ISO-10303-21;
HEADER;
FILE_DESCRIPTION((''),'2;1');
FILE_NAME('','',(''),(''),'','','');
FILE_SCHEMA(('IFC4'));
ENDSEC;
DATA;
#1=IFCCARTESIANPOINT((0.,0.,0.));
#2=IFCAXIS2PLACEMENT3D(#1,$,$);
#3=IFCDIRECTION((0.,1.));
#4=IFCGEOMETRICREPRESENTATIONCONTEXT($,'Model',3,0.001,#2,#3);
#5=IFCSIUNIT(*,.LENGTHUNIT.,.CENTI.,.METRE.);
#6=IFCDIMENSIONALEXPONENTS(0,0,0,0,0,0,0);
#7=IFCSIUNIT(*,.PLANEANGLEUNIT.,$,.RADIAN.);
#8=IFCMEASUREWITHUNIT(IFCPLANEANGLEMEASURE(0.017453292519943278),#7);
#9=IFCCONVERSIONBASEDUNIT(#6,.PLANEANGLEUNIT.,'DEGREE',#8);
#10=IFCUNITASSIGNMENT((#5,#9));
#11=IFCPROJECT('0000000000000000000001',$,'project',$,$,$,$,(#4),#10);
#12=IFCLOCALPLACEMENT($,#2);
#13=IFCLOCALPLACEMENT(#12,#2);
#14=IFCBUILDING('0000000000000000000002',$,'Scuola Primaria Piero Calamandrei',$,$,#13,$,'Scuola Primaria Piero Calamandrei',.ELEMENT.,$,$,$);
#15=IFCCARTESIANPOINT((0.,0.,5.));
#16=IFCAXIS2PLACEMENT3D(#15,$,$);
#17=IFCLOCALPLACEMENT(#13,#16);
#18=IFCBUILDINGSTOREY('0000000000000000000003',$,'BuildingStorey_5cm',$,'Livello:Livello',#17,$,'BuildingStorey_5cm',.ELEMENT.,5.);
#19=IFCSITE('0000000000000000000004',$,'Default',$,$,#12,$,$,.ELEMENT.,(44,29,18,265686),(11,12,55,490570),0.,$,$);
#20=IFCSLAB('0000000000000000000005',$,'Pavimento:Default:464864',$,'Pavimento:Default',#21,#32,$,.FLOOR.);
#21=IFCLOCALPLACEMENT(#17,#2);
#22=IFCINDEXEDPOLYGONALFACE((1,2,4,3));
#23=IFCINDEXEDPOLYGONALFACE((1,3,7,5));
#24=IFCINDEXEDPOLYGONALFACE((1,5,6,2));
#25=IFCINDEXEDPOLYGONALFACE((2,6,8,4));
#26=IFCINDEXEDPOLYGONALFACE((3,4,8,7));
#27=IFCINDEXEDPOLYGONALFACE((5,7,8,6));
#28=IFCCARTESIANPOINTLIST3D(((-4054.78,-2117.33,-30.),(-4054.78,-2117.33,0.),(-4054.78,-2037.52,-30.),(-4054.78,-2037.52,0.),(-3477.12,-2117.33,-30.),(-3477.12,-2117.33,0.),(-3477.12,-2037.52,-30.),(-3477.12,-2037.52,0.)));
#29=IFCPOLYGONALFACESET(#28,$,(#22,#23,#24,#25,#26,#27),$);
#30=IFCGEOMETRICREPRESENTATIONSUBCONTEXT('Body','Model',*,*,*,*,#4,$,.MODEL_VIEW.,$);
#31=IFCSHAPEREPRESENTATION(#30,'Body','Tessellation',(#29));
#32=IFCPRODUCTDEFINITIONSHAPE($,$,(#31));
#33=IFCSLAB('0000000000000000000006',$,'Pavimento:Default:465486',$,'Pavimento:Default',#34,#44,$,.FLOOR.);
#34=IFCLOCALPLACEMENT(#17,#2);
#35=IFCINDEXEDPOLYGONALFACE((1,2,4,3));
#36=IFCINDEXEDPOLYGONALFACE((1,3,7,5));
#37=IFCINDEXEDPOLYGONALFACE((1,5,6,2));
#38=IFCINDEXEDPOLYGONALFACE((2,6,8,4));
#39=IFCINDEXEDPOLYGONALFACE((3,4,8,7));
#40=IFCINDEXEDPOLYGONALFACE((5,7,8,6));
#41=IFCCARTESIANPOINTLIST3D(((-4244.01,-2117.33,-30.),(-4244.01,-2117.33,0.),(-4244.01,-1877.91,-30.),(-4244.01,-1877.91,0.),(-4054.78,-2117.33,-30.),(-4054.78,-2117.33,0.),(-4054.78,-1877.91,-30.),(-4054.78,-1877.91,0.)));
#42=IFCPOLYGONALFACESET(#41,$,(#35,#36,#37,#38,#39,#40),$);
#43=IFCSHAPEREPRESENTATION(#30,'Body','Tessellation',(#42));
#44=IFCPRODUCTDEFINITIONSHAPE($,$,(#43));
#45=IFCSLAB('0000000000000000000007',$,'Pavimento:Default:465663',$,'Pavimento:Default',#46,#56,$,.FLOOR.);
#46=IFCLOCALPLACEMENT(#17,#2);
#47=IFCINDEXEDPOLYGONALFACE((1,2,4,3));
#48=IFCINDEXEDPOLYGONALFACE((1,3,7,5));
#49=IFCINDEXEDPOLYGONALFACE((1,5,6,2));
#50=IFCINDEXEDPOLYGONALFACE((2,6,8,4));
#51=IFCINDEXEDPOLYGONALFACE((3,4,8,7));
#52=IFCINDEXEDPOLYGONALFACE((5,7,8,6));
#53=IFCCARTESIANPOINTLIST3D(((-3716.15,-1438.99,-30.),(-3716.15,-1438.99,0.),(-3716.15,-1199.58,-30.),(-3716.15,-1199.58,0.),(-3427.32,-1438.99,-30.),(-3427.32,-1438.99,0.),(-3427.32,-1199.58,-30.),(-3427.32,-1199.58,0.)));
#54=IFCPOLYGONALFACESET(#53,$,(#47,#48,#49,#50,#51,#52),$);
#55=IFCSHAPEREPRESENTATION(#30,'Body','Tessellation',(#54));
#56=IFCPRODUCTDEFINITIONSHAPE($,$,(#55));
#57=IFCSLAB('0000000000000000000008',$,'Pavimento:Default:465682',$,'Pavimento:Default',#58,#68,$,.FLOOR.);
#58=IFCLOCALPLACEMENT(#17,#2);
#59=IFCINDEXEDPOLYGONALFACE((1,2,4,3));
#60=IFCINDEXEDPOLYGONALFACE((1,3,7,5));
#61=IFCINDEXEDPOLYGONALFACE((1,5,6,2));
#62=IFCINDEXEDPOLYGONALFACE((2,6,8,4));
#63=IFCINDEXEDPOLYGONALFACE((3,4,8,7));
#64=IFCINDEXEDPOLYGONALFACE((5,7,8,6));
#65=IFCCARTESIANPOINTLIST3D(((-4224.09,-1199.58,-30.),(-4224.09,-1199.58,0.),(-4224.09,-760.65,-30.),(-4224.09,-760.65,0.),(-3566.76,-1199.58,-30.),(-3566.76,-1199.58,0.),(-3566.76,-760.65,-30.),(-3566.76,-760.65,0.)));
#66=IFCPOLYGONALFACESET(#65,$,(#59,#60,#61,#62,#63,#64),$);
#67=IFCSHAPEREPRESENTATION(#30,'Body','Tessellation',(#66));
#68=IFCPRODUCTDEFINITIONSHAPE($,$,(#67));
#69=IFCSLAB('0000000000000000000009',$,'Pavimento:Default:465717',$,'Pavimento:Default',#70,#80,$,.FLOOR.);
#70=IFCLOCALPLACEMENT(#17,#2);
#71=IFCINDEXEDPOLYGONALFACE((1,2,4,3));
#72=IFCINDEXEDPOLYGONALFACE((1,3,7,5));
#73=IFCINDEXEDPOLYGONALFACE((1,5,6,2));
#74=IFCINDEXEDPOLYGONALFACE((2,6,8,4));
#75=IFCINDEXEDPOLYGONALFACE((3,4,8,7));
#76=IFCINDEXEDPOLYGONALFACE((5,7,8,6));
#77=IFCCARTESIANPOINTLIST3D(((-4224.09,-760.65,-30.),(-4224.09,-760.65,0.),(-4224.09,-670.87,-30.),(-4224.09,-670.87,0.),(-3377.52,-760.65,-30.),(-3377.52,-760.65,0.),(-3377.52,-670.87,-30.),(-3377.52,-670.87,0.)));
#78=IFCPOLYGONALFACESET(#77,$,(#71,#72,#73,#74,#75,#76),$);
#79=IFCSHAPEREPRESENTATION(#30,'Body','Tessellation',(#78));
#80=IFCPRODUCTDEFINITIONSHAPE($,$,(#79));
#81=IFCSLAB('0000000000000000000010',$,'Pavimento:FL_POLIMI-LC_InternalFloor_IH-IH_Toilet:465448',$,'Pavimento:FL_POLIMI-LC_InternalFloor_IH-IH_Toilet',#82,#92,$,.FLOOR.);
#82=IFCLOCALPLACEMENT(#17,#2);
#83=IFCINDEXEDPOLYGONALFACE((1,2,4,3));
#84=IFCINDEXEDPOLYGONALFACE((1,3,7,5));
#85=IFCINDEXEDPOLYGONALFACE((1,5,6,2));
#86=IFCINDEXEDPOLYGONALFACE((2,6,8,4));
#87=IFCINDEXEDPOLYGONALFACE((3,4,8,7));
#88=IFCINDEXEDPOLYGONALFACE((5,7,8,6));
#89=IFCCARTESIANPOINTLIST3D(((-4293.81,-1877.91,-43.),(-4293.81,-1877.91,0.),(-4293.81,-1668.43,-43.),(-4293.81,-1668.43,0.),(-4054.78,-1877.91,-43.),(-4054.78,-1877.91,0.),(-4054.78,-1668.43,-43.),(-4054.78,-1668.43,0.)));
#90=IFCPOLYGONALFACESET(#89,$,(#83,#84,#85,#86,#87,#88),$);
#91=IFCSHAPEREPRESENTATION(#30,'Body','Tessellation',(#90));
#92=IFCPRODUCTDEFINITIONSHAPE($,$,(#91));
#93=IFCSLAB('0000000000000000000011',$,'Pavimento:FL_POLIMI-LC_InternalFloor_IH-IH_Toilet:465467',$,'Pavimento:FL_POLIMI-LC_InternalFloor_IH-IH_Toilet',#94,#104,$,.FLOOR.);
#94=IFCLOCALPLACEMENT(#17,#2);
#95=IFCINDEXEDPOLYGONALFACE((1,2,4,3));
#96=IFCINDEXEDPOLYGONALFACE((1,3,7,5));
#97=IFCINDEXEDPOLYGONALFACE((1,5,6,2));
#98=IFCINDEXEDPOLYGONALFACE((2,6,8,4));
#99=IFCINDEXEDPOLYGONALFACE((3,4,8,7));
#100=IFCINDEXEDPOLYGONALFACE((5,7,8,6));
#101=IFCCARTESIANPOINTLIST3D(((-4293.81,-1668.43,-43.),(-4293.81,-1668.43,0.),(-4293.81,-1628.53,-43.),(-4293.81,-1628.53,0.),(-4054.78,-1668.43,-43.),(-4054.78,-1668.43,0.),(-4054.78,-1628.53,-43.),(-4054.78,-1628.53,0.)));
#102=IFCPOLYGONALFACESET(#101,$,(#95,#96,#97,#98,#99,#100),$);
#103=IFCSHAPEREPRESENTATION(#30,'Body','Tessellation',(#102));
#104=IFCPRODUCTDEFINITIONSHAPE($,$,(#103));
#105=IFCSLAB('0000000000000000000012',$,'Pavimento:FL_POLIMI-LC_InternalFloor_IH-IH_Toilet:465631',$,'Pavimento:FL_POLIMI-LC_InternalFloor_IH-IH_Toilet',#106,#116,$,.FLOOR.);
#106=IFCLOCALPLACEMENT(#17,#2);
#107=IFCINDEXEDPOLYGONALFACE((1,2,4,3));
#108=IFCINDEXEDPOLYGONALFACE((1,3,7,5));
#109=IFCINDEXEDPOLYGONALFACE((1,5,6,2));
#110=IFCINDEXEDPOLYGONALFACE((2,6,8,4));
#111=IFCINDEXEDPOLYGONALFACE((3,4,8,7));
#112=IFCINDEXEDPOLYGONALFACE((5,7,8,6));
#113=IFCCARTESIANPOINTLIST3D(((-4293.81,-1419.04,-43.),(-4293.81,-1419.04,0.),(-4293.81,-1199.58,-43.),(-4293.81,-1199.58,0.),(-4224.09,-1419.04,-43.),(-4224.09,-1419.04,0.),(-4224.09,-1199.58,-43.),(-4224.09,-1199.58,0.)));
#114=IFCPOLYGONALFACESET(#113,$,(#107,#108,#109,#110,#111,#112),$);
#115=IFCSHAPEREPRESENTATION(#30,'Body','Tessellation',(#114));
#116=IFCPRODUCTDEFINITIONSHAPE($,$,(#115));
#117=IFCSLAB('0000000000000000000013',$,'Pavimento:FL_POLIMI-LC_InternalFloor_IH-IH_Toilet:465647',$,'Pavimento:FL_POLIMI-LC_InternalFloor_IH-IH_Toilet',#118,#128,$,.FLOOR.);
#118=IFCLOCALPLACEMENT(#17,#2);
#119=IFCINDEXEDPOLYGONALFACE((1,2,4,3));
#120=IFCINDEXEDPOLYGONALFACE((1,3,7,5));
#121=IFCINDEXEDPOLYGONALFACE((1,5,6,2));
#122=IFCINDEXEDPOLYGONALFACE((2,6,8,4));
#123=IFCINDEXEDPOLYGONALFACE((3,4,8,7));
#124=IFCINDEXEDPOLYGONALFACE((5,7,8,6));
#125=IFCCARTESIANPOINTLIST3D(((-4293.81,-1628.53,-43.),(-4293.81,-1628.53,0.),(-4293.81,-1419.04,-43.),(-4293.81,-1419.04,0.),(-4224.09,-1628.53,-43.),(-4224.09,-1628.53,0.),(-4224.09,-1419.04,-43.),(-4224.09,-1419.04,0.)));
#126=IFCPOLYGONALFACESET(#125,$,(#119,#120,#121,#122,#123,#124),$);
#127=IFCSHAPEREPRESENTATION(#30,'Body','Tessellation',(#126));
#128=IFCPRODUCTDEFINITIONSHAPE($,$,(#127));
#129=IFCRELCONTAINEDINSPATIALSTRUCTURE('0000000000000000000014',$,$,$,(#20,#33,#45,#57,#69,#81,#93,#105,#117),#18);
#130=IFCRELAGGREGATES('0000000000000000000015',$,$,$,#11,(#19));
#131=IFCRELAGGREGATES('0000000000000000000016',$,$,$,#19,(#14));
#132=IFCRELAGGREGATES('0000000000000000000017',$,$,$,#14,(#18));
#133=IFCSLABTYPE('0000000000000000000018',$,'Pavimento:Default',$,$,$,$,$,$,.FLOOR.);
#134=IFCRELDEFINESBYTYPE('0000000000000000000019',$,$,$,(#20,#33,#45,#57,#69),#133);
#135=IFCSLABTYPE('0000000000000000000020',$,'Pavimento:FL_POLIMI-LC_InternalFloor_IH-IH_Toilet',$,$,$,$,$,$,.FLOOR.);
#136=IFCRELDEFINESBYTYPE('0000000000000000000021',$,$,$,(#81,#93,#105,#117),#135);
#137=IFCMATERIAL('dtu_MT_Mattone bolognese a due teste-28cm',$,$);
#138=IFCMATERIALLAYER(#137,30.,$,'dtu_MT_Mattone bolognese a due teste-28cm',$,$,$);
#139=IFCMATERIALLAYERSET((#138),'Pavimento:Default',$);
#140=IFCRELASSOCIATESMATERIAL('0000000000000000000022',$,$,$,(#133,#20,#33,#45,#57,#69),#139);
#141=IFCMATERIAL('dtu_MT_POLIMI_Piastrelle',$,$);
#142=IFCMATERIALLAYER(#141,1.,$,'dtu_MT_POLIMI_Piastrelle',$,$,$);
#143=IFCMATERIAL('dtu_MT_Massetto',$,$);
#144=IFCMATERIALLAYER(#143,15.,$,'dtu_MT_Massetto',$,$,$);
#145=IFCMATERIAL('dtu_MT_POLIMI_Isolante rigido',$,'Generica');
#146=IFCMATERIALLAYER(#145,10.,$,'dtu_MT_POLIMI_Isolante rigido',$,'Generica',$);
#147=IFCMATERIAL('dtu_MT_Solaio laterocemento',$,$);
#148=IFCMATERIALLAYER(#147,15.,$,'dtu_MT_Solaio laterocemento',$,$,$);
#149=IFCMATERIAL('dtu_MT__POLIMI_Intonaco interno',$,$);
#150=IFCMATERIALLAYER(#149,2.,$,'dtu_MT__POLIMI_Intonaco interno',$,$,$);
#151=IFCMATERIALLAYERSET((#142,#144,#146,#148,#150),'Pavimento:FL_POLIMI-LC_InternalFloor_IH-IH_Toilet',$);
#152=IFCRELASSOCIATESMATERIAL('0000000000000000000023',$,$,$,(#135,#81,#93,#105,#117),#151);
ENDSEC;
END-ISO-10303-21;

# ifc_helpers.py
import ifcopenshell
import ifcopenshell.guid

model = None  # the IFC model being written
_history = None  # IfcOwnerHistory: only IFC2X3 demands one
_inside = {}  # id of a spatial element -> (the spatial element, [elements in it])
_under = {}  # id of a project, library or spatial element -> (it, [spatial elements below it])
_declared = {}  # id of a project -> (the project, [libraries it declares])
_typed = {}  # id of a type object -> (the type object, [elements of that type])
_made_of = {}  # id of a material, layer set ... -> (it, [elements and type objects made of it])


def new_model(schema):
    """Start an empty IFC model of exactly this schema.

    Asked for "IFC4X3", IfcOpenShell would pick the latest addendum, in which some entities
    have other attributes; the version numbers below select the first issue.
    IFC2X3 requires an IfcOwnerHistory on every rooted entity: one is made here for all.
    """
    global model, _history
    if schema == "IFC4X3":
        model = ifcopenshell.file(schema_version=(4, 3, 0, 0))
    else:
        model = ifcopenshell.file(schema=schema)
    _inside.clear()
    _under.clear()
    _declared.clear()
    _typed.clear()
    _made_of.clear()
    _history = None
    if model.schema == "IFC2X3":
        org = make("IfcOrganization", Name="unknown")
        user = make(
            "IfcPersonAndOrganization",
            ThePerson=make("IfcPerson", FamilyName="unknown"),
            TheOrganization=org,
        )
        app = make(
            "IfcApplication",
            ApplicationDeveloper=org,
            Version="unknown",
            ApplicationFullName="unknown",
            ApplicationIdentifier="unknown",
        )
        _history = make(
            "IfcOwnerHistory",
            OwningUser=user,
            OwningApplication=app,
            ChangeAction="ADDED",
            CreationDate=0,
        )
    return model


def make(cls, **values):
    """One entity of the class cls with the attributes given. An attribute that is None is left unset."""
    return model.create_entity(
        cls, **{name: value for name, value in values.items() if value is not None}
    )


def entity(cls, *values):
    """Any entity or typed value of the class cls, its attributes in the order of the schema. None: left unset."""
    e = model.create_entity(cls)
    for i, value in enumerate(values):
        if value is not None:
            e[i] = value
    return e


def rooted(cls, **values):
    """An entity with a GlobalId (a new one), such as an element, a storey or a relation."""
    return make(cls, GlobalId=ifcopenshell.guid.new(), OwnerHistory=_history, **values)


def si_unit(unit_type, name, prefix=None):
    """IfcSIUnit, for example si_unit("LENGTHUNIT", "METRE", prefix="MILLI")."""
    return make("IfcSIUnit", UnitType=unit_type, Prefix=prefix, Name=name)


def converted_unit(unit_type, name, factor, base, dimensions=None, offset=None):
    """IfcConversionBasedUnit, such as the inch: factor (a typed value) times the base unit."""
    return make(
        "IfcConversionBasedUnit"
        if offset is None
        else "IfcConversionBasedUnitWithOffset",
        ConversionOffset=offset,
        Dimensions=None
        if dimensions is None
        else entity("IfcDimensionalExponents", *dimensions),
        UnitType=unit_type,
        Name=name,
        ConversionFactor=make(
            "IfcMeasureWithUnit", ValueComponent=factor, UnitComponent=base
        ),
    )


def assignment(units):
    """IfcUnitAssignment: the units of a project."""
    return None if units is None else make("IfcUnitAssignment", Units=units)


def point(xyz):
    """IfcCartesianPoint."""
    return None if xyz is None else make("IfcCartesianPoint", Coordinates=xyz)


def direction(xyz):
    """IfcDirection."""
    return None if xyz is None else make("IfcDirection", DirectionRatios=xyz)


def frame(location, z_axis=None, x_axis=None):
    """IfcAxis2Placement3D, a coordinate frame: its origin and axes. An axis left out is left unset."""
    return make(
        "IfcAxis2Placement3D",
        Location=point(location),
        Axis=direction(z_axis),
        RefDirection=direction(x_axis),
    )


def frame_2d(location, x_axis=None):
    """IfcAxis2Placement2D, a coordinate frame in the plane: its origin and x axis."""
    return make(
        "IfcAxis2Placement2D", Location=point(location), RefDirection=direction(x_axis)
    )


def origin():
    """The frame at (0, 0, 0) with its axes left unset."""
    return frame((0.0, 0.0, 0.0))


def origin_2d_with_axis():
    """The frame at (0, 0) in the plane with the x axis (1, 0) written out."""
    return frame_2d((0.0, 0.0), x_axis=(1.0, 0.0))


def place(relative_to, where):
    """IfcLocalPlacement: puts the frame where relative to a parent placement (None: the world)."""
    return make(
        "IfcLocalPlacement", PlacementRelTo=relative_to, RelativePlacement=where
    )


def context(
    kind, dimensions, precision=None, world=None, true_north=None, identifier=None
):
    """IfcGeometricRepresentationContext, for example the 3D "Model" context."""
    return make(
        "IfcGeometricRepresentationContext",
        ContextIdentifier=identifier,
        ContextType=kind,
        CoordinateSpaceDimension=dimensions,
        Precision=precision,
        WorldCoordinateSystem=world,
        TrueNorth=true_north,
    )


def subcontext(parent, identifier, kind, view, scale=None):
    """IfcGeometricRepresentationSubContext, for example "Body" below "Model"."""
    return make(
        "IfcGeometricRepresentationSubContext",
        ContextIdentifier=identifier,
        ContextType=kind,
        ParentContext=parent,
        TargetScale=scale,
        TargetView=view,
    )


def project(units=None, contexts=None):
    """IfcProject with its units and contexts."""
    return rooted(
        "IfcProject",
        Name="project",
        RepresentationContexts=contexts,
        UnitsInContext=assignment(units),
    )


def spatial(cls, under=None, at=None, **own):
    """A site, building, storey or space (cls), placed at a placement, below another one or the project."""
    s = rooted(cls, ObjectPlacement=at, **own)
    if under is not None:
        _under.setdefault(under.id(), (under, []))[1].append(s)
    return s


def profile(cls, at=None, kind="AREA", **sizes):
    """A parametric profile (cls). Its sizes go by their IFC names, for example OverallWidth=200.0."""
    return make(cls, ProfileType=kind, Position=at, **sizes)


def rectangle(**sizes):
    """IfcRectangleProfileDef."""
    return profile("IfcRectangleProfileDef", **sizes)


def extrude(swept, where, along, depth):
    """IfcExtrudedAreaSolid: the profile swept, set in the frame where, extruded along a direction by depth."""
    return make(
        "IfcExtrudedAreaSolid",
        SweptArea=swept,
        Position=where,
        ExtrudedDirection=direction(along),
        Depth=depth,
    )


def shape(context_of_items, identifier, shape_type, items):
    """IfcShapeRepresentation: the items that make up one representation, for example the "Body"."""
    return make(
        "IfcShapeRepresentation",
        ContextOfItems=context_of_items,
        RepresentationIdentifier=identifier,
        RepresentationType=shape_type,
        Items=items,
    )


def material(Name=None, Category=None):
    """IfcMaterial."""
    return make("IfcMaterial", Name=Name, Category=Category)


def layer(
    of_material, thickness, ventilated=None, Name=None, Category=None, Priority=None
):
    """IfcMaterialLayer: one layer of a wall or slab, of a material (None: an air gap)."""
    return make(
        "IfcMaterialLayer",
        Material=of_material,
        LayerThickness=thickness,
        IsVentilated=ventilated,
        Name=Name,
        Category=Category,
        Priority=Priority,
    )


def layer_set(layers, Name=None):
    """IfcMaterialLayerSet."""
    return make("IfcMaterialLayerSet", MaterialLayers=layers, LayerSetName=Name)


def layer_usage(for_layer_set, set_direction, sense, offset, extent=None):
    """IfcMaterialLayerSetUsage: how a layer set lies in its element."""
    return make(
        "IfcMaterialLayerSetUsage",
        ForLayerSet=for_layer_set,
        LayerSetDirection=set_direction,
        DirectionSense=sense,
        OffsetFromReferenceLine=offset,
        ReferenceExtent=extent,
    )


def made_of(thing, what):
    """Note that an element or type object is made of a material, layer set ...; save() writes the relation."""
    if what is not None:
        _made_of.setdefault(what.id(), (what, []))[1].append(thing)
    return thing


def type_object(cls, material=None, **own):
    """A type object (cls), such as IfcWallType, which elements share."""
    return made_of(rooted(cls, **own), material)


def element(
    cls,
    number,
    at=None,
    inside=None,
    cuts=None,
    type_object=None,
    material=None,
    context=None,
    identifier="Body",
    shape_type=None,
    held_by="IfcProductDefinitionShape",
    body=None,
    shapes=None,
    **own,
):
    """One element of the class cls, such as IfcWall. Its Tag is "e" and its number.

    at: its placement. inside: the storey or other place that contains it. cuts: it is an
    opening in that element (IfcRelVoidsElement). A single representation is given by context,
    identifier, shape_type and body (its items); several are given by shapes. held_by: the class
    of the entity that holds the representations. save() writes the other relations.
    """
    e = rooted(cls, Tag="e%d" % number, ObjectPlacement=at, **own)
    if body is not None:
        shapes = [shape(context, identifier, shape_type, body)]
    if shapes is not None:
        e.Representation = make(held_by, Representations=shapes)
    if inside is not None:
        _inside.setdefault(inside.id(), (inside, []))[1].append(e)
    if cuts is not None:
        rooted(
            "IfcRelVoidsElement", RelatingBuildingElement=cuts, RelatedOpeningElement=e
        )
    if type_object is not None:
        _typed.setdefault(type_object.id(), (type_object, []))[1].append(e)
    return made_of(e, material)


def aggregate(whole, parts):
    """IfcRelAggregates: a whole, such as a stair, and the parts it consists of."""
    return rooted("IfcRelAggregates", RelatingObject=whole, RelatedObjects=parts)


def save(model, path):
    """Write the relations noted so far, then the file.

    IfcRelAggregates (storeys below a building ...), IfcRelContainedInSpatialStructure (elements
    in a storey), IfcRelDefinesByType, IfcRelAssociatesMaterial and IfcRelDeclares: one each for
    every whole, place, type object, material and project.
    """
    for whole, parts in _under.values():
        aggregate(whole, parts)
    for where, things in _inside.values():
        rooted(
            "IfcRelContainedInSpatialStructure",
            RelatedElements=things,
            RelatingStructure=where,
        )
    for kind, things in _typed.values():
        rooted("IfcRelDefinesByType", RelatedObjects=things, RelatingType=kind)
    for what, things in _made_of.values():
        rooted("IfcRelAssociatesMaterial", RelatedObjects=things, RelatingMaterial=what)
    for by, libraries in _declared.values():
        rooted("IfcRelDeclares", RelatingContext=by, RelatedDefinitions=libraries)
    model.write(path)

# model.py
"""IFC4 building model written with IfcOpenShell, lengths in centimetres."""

from ifc_helpers import new_model, entity, si_unit, converted_unit, direction, frame, frame_2d, origin, origin_2d_with_axis, place, context, subcontext, project, spatial, rectangle, extrude, material, layer, layer_set, layer_usage, type_object, element, save


model = new_model("IFC4")

# Units and contexts
model_context = context("Model", 3, precision=0.001, world=origin(), true_north=direction((0.0, 1.0)))
body_context = subcontext(model_context, "Body", "Model", "MODEL_VIEW")
ifc_project = project(units=[si_unit("LENGTHUNIT", "METRE", prefix="CENTI"), converted_unit("PLANEANGLEUNIT", "DEGREE", entity("IfcPlaneAngleMeasure", 0.017453292519943278), si_unit("PLANEANGLEUNIT", "RADIAN"), dimensions=[0, 0, 0, 0, 0, 0, 0])], contexts=[model_context])

# Site, building, storey
site_placement = place(None, origin())
site = spatial("IfcSite", under=ifc_project, at=site_placement, Name="Default", CompositionType="ELEMENT", RefLatitude=(44, 29, 18, 265686), RefLongitude=(11, 12, 55, 490570), RefElevation=0.0)
building_placement = place(site_placement, origin())
building = spatial("IfcBuilding", under=site, at=building_placement, Name="Scuola Primaria Piero Calamandrei", LongName="Scuola Primaria Piero Calamandrei", CompositionType="ELEMENT")
storey_placement = place(building_placement, frame((0.0, 0.0, 5.0)))
storey = spatial("IfcBuildingStorey", under=building, at=storey_placement, Name="BuildingStorey_5cm", ObjectType="Livello:Livello", LongName="BuildingStorey_5cm", CompositionType="ELEMENT", Elevation=5.0)

# Slabs
ifc_material_1 = material(Name="dtu_MT_Massetto")
ifc_material_2 = material(Name="dtu_MT_POLIMI_Isolante rigido", Category="Generica")
ifc_material_3 = material(Name="dtu_MT_Solaio laterocemento")
ifc_material_4 = material(Name="dtu_MT__POLIMI_Intonaco interno")
ifc_material_5 = material(Name="dtu_MT_Mattone bolognese a due teste-28cm")
ifc_layer_1 = layer(ifc_material_5, 30.0, Name="dtu_MT_Mattone bolognese a due teste-28cm")
ifc_layer_set_1 = layer_set([ifc_layer_1], Name="Pavimento:Default")
ifc_layer_usage_1 = layer_usage(ifc_layer_set_1, "AXIS3", "POSITIVE", 0.0)
slab_type_1 = type_object("IfcSlabType", Name="Pavimento:Default", PredefinedType="FLOOR", material=ifc_layer_set_1)
slab_1_placement = place(storey_placement, origin())
element("IfcSlab", 1, at=slab_1_placement, inside=storey, type_object=slab_type_1, material=ifc_layer_usage_1, Name="Pavimento:Default:464864", ObjectType="Pavimento:Default", PredefinedType="FLOOR", context=body_context, shape_type="SweptSolid", body=[
    extrude(rectangle(XDim=79.8, YDim=577.66, at=frame_2d((0.0, 0.0), x_axis=(1.0, 0.0))), frame((-3765.95, -2077.42, 0.0), z_axis=(0.0, 0.0, -1.0), x_axis=(0.0, 1.0, 0.0)), (0.0, 0.0, 1.0), 30.0),
])
ifc_layer_usage_2 = layer_usage(ifc_layer_set_1, "AXIS3", "POSITIVE", 0.0)
slab_2_placement = place(storey_placement, origin())
element("IfcSlab", 2, at=slab_2_placement, inside=storey, type_object=slab_type_1, material=ifc_layer_usage_2, Name="Pavimento:Default:465486", ObjectType="Pavimento:Default", PredefinedType="FLOOR", context=body_context, shape_type="SweptSolid", body=[
    extrude(rectangle(XDim=239.41, YDim=189.23, at=frame_2d((0.0, 0.0), x_axis=(1.0, 0.0))), frame((-4149.39, -1997.62, 0.0), z_axis=(0.0, 0.0, -1.0), x_axis=(0.0, 1.0, 0.0)), (0.0, 0.0, 1.0), 30.0),
])
ifc_layer_usage_3 = layer_usage(ifc_layer_set_1, "AXIS3", "POSITIVE", 0.0)
slab_3_placement = place(storey_placement, origin())
element("IfcSlab", 3, at=slab_3_placement, inside=storey, type_object=slab_type_1, material=ifc_layer_usage_3, Name="Pavimento:Default:465663", ObjectType="Pavimento:Default", PredefinedType="FLOOR", context=body_context, shape_type="SweptSolid", body=[
    extrude(rectangle(XDim=239.41, YDim=288.83, at=origin_2d_with_axis()), frame((-3571.74, -1319.28, 0.0), z_axis=(0.0, 0.0, -1.0), x_axis=(0.0, 1.0, 0.0)), (0.0, 0.0, 1.0), 30.0),
])
ifc_layer_usage_4 = layer_usage(ifc_layer_set_1, "AXIS3", "POSITIVE", 0.0)
slab_4_placement = place(storey_placement, origin())
element("IfcSlab", 4, at=slab_4_placement, inside=storey, type_object=slab_type_1, material=ifc_layer_usage_4, Name="Pavimento:Default:465682", ObjectType="Pavimento:Default", PredefinedType="FLOOR", context=body_context, shape_type="SweptSolid", body=[
    extrude(rectangle(XDim=438.92, YDim=657.33, at=frame_2d((0.0, 0.0), x_axis=(1.0, 0.0))), frame((-3895.42, -980.11, 0.0), z_axis=(0.0, 0.0, -1.0), x_axis=(0.0, 1.0, 0.0)), (0.0, 0.0, 1.0), 30.0),
])
ifc_layer_usage_5 = layer_usage(ifc_layer_set_1, "AXIS3", "POSITIVE", 0.0)
slab_5_placement = place(storey_placement, origin())
element("IfcSlab", 5, at=slab_5_placement, inside=storey, type_object=slab_type_1, material=ifc_layer_usage_5, Name="Pavimento:Default:465717", ObjectType="Pavimento:Default", PredefinedType="FLOOR", context=body_context, shape_type="SweptSolid", body=[
    extrude(rectangle(XDim=89.78, YDim=846.57, at=frame_2d((0.0, 0.0), x_axis=(1.0, 0.0))), frame((-3800.81, -715.76, 0.0), z_axis=(0.0, 0.0, -1.0), x_axis=(0.0, 1.0, 0.0)), (0.0, 0.0, 1.0), 30.0),
])
ifc_material_6 = material(Name="dtu_MT_POLIMI_Piastrelle")
ifc_layer_2 = layer(ifc_material_6, 1.0, Name="dtu_MT_POLIMI_Piastrelle")
ifc_layer_3 = layer(ifc_material_1, 15.0, Name="dtu_MT_Massetto")
ifc_layer_4 = layer(ifc_material_2, 10.0, Name="dtu_MT_POLIMI_Isolante rigido", Category="Generica")
ifc_layer_5 = layer(ifc_material_3, 15.0, Name="dtu_MT_Solaio laterocemento")
ifc_layer_6 = layer(ifc_material_4, 2.0, Name="dtu_MT__POLIMI_Intonaco interno")
ifc_layer_set_2 = layer_set([ifc_layer_2, ifc_layer_3, ifc_layer_4, ifc_layer_5, ifc_layer_6], Name="Pavimento:FL_POLIMI-LC_InternalFloor_IH-IH_Toilet")
ifc_layer_usage_6 = layer_usage(ifc_layer_set_2, "AXIS3", "POSITIVE", 0.0)
slab_type_2 = type_object("IfcSlabType", Name="Pavimento:FL_POLIMI-LC_InternalFloor_IH-IH_Toilet", PredefinedType="FLOOR", material=ifc_layer_set_2)
slab_6_placement = place(storey_placement, origin())
element("IfcSlab", 6, at=slab_6_placement, inside=storey, type_object=slab_type_2, material=ifc_layer_usage_6, Name="Pavimento:FL_POLIMI-LC_InternalFloor_IH-IH_Toilet:465448", ObjectType="Pavimento:FL_POLIMI-LC_InternalFloor_IH-IH_Toilet", PredefinedType="FLOOR", context=body_context, shape_type="SweptSolid", body=[
    extrude(rectangle(XDim=209.49, YDim=239.03, at=frame_2d((0.0, 0.0), x_axis=(1.0, 0.0))), frame((-4174.29, -1773.17, 0.0), z_axis=(0.0, 0.0, -1.0), x_axis=(0.0, 1.0, 0.0)), (0.0, 0.0, 1.0), 43.0),
])
ifc_layer_usage_7 = layer_usage(ifc_layer_set_2, "AXIS3", "POSITIVE", 0.0)
slab_7_placement = place(storey_placement, origin())
element("IfcSlab", 7, at=slab_7_placement, inside=storey, type_object=slab_type_2, material=ifc_layer_usage_7, Name="Pavimento:FL_POLIMI-LC_InternalFloor_IH-IH_Toilet:465467", ObjectType="Pavimento:FL_POLIMI-LC_InternalFloor_IH-IH_Toilet", PredefinedType="FLOOR", context=body_context, shape_type="SweptSolid", body=[
    extrude(rectangle(XDim=39.9, YDim=239.03, at=frame_2d((0.0, 0.0), x_axis=(1.0, 0.0))), frame((-4174.29, -1648.48, 0.0), z_axis=(0.0, 0.0, -1.0), x_axis=(0.0, 1.0, 0.0)), (0.0, 0.0, 1.0), 43.0),
])
ifc_layer_usage_8 = layer_usage(ifc_layer_set_2, "AXIS3", "POSITIVE", 0.0)
slab_8_placement = place(storey_placement, origin())
element("IfcSlab", 8, at=slab_8_placement, inside=storey, type_object=slab_type_2, material=ifc_layer_usage_8, Name="Pavimento:FL_POLIMI-LC_InternalFloor_IH-IH_Toilet:465631", ObjectType="Pavimento:FL_POLIMI-LC_InternalFloor_IH-IH_Toilet", PredefinedType="FLOOR", context=body_context, shape_type="SweptSolid", body=[
    extrude(rectangle(XDim=219.46, YDim=69.72, at=origin_2d_with_axis()), frame((-4258.95, -1309.31, 0.0), z_axis=(0.0, 0.0, -1.0), x_axis=(0.0, 1.0, 0.0)), (0.0, 0.0, 1.0), 43.0),
])
ifc_layer_usage_9 = layer_usage(ifc_layer_set_2, "AXIS3", "POSITIVE", 0.0)
slab_9_placement = place(storey_placement, origin())
element("IfcSlab", 9, at=slab_9_placement, inside=storey, type_object=slab_type_2, material=ifc_layer_usage_9, Name="Pavimento:FL_POLIMI-LC_InternalFloor_IH-IH_Toilet:465647", ObjectType="Pavimento:FL_POLIMI-LC_InternalFloor_IH-IH_Toilet", PredefinedType="FLOOR", context=body_context, shape_type="SweptSolid", body=[
    extrude(rectangle(XDim=209.49, YDim=69.72, at=frame_2d((0.0, 0.0), x_axis=(1.0, 0.0))), frame((-4258.95, -1523.78, 0.0), z_axis=(0.0, 0.0, -1.0), x_axis=(0.0, 1.0, 0.0)), (0.0, 0.0, 1.0), 43.0),
])

save(model, "model.ifc")
